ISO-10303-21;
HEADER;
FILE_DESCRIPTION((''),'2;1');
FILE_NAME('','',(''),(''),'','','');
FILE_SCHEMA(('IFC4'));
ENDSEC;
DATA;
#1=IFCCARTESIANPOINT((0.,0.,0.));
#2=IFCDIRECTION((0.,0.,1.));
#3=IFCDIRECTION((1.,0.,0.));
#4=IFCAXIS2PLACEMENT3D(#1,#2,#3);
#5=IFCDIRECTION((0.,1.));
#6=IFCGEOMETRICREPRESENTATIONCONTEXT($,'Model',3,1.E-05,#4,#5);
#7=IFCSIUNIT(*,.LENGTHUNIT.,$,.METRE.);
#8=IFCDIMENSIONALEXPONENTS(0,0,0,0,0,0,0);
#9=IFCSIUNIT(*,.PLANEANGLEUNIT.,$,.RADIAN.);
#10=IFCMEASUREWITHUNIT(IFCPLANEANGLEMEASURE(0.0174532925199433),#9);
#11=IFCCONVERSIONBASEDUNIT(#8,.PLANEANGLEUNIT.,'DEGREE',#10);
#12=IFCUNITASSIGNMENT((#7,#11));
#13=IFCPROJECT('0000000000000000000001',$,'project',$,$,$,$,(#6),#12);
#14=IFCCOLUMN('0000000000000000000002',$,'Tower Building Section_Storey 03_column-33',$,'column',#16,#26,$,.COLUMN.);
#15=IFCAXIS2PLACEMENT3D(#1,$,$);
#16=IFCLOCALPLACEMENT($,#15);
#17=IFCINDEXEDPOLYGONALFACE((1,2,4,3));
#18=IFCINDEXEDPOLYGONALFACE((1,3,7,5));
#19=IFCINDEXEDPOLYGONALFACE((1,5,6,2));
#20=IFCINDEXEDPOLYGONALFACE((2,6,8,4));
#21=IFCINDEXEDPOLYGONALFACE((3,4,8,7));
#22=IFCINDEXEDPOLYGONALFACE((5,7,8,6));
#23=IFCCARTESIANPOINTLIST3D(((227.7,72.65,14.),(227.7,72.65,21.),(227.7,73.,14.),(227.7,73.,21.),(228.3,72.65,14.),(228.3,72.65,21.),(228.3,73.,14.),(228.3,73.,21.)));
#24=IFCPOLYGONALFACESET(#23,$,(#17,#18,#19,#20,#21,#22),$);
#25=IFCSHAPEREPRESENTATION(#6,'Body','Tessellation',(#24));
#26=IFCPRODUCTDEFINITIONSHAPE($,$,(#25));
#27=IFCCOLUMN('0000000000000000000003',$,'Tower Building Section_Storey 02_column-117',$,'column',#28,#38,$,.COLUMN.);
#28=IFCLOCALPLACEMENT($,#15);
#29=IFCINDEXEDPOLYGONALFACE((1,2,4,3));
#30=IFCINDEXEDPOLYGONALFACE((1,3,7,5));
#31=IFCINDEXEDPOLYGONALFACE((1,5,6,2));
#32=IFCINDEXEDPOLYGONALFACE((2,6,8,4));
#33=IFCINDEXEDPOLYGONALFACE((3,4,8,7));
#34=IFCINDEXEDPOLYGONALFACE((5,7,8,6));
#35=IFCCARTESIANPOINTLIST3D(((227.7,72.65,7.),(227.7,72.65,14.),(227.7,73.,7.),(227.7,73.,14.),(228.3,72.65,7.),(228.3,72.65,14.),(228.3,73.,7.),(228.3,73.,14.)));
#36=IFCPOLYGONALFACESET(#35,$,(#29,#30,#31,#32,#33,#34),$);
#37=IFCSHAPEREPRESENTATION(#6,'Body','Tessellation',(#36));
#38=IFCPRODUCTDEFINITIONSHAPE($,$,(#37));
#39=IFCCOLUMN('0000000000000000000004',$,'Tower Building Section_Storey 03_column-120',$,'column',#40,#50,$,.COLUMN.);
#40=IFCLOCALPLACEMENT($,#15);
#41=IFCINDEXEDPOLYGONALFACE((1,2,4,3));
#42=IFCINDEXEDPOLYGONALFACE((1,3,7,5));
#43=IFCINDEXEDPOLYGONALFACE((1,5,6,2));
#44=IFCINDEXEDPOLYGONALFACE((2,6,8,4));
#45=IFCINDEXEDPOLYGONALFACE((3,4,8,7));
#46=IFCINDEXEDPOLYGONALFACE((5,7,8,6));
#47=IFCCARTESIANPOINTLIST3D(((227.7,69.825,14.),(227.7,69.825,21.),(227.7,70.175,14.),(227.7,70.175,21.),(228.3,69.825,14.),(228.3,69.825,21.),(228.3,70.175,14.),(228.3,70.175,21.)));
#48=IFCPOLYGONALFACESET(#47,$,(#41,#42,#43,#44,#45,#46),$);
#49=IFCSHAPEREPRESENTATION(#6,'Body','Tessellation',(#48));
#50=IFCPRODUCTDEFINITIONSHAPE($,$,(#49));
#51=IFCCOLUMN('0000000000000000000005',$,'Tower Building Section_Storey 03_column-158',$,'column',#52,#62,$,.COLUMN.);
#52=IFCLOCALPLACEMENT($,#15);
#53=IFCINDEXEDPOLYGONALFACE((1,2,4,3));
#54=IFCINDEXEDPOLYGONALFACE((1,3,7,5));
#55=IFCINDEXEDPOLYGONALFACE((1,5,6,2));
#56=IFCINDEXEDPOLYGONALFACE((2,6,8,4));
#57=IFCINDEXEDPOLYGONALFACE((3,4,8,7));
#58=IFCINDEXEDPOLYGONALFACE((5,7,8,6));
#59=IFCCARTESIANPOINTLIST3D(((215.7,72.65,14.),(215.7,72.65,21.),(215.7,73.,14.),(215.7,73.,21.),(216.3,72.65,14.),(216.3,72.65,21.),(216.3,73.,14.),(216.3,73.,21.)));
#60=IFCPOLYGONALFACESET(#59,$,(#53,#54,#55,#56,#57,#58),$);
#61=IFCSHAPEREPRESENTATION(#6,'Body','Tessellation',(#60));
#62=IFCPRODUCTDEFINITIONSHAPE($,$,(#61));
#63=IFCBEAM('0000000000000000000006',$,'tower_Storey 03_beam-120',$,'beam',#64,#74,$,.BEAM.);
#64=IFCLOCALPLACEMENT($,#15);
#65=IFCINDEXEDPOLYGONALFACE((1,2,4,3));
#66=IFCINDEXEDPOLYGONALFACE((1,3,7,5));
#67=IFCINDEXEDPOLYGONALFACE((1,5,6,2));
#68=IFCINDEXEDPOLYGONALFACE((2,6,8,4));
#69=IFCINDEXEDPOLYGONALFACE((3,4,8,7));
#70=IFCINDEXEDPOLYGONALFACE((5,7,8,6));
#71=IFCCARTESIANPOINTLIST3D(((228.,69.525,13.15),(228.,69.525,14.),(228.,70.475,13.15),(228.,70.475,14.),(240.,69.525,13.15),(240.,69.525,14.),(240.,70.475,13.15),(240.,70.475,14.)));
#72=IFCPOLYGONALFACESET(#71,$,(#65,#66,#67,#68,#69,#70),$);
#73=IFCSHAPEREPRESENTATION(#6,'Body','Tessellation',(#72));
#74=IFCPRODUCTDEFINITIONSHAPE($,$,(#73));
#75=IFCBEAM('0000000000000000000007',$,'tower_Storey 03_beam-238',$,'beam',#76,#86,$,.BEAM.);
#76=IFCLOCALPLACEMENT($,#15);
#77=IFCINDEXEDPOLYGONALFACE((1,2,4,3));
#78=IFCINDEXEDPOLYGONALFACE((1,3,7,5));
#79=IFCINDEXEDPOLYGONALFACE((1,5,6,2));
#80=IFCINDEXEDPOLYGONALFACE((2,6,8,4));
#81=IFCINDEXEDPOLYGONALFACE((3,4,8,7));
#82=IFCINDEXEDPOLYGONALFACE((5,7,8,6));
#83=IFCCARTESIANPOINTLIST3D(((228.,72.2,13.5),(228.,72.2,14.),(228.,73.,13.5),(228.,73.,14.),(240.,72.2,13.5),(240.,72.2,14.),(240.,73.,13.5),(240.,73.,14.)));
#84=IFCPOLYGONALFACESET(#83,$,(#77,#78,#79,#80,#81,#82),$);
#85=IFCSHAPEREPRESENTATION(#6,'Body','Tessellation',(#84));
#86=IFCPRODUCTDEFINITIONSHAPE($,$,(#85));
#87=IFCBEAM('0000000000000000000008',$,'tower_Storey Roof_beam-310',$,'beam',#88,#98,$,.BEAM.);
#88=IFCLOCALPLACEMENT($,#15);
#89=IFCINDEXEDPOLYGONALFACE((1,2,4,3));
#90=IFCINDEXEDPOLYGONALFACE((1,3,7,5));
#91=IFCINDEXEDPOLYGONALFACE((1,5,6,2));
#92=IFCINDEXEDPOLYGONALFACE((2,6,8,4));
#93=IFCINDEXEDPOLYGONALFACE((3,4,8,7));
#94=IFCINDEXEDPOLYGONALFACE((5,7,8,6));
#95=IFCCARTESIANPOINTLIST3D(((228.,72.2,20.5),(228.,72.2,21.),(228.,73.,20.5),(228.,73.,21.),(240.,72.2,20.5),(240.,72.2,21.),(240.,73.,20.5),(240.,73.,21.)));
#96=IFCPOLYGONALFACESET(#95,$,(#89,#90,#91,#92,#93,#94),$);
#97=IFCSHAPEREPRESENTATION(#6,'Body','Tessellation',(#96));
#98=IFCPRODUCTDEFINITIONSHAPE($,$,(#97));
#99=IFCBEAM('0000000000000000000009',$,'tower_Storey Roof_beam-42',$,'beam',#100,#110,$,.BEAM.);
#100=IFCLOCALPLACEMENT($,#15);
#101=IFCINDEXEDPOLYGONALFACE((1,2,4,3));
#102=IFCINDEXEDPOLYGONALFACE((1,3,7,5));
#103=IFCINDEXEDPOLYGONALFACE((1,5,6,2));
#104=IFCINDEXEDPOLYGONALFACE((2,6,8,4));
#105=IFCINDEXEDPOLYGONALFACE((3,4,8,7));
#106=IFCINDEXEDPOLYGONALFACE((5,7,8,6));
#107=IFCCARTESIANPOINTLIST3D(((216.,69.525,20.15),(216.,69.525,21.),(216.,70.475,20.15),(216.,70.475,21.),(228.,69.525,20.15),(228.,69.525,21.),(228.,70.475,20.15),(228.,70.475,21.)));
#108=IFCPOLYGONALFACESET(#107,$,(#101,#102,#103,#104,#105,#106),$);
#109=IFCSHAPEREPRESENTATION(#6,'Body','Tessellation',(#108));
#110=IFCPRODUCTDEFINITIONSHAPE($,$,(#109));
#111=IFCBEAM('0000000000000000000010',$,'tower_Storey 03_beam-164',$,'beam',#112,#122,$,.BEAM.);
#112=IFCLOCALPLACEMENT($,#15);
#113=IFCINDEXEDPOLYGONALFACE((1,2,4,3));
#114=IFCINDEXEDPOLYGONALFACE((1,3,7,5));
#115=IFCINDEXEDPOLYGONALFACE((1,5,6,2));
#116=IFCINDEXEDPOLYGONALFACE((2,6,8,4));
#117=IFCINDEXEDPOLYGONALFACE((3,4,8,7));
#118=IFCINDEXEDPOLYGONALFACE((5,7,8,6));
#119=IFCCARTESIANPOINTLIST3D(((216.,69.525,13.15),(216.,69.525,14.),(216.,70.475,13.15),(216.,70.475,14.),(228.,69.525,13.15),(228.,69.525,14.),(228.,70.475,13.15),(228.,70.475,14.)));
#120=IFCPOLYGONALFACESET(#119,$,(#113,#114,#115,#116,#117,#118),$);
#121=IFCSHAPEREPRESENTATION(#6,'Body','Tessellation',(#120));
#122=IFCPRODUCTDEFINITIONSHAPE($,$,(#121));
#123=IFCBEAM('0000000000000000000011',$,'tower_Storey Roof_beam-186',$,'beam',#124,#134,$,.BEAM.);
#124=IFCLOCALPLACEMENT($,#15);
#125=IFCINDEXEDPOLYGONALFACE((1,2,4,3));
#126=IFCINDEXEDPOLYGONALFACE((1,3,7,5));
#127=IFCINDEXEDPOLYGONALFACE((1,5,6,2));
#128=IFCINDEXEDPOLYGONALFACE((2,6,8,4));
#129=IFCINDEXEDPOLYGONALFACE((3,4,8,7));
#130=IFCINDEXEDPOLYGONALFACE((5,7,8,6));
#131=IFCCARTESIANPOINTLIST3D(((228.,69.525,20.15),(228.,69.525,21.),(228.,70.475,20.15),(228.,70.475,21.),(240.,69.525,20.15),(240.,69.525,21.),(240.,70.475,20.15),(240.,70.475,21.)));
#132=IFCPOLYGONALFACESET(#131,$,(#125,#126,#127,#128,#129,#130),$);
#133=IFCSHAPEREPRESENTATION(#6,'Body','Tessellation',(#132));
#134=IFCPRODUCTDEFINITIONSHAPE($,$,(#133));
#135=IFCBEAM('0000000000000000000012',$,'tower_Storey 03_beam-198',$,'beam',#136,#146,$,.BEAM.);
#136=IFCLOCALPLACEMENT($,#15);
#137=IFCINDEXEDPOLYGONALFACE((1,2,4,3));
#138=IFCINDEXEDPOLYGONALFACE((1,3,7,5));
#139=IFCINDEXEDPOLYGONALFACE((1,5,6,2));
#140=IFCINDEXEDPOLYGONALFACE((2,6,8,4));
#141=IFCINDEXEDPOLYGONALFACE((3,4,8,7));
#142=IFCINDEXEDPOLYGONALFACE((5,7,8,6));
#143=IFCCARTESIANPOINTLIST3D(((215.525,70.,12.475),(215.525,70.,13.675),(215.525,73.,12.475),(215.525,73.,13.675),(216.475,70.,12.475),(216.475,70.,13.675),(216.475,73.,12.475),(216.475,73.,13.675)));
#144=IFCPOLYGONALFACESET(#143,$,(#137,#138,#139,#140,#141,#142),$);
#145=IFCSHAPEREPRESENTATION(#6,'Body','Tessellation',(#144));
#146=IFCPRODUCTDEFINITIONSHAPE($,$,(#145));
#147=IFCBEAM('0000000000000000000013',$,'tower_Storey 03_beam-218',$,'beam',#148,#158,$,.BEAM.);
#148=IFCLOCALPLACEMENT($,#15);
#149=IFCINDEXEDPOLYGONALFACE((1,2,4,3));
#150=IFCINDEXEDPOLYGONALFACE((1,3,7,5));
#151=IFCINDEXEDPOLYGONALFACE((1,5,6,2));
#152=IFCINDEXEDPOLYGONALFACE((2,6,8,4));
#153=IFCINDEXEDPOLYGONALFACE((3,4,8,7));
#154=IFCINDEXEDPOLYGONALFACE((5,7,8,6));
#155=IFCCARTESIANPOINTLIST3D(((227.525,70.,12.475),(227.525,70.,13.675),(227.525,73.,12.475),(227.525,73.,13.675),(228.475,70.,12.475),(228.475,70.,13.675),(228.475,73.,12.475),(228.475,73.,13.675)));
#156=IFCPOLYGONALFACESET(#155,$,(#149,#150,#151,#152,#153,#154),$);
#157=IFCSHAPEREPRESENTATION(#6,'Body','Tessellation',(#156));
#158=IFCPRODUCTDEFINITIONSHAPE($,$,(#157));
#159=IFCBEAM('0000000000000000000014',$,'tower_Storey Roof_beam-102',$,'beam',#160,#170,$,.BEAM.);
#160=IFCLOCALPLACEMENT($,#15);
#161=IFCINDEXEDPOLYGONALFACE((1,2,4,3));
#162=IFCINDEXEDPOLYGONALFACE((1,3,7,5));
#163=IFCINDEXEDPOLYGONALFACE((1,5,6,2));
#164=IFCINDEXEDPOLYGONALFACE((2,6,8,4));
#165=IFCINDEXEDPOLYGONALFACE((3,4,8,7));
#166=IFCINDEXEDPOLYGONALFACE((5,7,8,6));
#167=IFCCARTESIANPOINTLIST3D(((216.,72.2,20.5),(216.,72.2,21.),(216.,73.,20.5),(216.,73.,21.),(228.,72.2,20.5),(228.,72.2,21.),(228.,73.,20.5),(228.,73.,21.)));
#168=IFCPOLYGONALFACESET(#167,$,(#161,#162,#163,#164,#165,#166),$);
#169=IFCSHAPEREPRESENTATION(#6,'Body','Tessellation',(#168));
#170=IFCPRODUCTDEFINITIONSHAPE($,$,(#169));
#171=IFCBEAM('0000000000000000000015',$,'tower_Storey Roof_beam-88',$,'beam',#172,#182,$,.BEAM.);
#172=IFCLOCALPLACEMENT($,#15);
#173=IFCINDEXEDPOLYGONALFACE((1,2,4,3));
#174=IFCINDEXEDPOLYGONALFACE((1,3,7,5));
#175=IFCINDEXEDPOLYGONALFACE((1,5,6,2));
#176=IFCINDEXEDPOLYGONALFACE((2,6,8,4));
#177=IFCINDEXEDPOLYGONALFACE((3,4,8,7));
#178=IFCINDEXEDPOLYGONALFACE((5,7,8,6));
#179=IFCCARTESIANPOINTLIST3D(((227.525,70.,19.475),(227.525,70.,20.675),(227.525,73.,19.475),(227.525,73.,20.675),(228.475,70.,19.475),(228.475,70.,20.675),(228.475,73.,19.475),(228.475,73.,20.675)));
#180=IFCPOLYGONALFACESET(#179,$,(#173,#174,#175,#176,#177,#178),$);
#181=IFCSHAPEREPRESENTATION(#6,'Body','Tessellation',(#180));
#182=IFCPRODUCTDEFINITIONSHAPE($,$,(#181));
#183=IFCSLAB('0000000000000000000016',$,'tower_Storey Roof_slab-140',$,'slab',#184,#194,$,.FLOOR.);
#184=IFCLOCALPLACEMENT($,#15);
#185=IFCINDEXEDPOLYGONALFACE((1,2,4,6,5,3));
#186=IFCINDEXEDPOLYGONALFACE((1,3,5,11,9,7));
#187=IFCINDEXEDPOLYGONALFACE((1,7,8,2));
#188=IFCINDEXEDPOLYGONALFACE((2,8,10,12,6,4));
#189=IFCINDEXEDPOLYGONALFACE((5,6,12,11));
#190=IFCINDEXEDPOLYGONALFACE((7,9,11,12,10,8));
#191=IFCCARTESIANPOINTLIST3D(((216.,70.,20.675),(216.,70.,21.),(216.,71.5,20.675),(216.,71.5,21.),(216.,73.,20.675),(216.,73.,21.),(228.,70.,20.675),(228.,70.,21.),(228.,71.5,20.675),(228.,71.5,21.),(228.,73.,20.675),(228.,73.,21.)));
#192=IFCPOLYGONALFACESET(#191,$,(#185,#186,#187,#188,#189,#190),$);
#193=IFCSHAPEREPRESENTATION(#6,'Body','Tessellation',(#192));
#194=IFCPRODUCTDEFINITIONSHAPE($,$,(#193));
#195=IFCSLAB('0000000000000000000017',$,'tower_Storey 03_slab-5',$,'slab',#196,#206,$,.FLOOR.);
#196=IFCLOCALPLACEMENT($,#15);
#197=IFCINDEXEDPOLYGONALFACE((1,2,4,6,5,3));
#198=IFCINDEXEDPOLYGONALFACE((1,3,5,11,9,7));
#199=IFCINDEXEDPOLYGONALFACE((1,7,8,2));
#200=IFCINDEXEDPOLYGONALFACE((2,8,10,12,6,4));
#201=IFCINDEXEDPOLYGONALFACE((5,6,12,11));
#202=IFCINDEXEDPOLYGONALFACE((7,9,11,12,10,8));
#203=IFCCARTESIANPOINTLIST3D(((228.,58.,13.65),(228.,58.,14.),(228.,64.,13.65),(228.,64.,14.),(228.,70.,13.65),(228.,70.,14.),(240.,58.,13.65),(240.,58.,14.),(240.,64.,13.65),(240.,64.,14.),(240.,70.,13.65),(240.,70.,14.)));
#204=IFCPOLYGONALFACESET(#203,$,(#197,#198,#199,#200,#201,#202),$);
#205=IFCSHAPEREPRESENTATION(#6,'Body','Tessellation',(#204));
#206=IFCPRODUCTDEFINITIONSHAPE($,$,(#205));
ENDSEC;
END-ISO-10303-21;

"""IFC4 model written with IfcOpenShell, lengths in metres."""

from ifc_helpers import new_model, entity, si_unit, converted_unit, direction, frame, origin_with_axes, place, context, project, polyline, outline, extrude, element, save


model = new_model("IFC4")

# Units and contexts
model_context = context("Model", 3, precision=1e-05, world=origin_with_axes(), true_north=direction((0.0, 1.0)))
ifc_project = project(units=[si_unit("LENGTHUNIT", "METRE"), converted_unit("PLANEANGLEUNIT", "DEGREE", entity("IfcPlaneAngleMeasure", 0.0174532925199433), si_unit("PLANEANGLEUNIT", "RADIAN"), dimensions=[0, 0, 0, 0, 0, 0, 0])], contexts=[model_context])

# Columns
placement_1 = place(None, origin_with_axes())
placement_2 = place(placement_1, frame((0.0, 0.0, 14.0), z_axis=(0.0, 0.0, 1.0), x_axis=(1.0, 0.0, 0.0)))
column_1_placement = place(placement_2, frame((228.0, 72.825, 0.0), z_axis=(0.0, 0.0, 1.0), x_axis=(1.0, 0.0, 0.0)))
element("IfcColumn", 1, at=column_1_placement, Name="Tower Building Section_Storey 03_column-33", ObjectType="column", PredefinedType="COLUMN", context=model_context, body=[
    extrude(outline(polyline([(-0.3, -0.175, 0.0), (0.3, -0.175, 0.0), (0.3, 0.175, 0.0), (-0.3, 0.175, 0.0), (-0.3, -0.175, 0.0)])), origin_with_axes(), (0.0, 0.0, 1.0), 7.0),
])
placement_3 = place(placement_1, frame((0.0, 0.0, 7.0), z_axis=(0.0, 0.0, 1.0), x_axis=(1.0, 0.0, 0.0)))
column_2_placement = place(placement_3, frame((228.0, 72.825, 0.0), z_axis=(0.0, 0.0, 1.0), x_axis=(1.0, 0.0, 0.0)))
element("IfcColumn", 2, at=column_2_placement, Name="Tower Building Section_Storey 02_column-117", ObjectType="column", PredefinedType="COLUMN", context=model_context, body=[
    extrude(outline(polyline([(-0.3, -0.175, 0.0), (0.3, -0.175, 0.0), (0.3, 0.175, 0.0), (-0.3, 0.175, 0.0), (-0.3, -0.175, 0.0)])), origin_with_axes(), (0.0, 0.0, 1.0), 7.0),
])
for number, where, z_axis, x_axis, name in (
    (3, (228.0, 70.0, 0.0), (0.0, 0.0, 1.0), (1.0, 0.0, 0.0), "Tower Building Section_Storey 03_column-120"),
    (4, (216.0, 72.825, 0.0), (0.0, 0.0, 1.0), (1.0, 0.0, 0.0), "Tower Building Section_Storey 03_column-158"),
):
    element("IfcColumn", number, at=place(placement_2, frame(where, z_axis=z_axis, x_axis=x_axis)), Name=name, ObjectType="column", PredefinedType="COLUMN", context=model_context, body=[
        extrude(outline(polyline([(-0.3, -0.175, 0.0), (0.3, -0.175, 0.0), (0.3, 0.175, 0.0), (-0.3, 0.175, 0.0), (-0.3, -0.175, 0.0)])), origin_with_axes(), (0.0, 0.0, 1.0), 7.0),
    ])

# Beams
beam_1_placement = place(placement_2, frame((228.0, 70.0, -0.425), z_axis=(1.0, 0.0, 0.0), x_axis=(0.0, 1.0, 0.0)))
element("IfcBeam", 5, at=beam_1_placement, Name="tower_Storey 03_beam-120", ObjectType="beam", PredefinedType="BEAM", context=model_context, body=[
    extrude(outline(polyline([(0.475, 0.425, 0.0), (-0.475, 0.425, 0.0), (-0.475, -0.425, 0.0), (0.475, -0.425, 0.0), (0.475, 0.425, 0.0)])), origin_with_axes(), (0.0, 0.0, 1.0), 12.0),
])
beam_2_placement = place(placement_2, frame((228.0, 72.6, -0.25), z_axis=(1.0, 0.0, 0.0), x_axis=(0.0, 1.0, 0.0)))
element("IfcBeam", 6, at=beam_2_placement, Name="tower_Storey 03_beam-238", ObjectType="beam", PredefinedType="BEAM", context=model_context, body=[
    extrude(outline(polyline([(0.4, 0.25, 0.0), (-0.4, 0.25, 0.0), (-0.4, -0.25, 0.0), (0.4, -0.25, 0.0), (0.4, 0.25, 0.0)])), origin_with_axes(), (0.0, 0.0, 1.0), 12.0),
])
placement_4 = place(placement_1, frame((0.0, 0.0, 21.0), z_axis=(0.0, 0.0, 1.0), x_axis=(1.0, 0.0, 0.0)))
beam_3_placement = place(placement_4, frame((228.0, 72.6, -0.25), z_axis=(1.0, 0.0, 0.0), x_axis=(0.0, 1.0, 0.0)))
element("IfcBeam", 7, at=beam_3_placement, Name="tower_Storey Roof_beam-310", ObjectType="beam", PredefinedType="BEAM", context=model_context, body=[
    extrude(outline(polyline([(0.4, 0.25, 0.0), (-0.4, 0.25, 0.0), (-0.4, -0.25, 0.0), (0.4, -0.25, 0.0), (0.4, 0.25, 0.0)])), origin_with_axes(), (0.0, 0.0, 1.0), 12.0),
])
beam_4_placement = place(placement_4, frame((216.0, 70.0, -0.425), z_axis=(1.0, 0.0, 0.0), x_axis=(0.0, 1.0, 0.0)))
element("IfcBeam", 8, at=beam_4_placement, Name="tower_Storey Roof_beam-42", ObjectType="beam", PredefinedType="BEAM", context=model_context, body=[
    extrude(outline(polyline([(0.475, 0.425, 0.0), (-0.475, 0.425, 0.0), (-0.475, -0.425, 0.0), (0.475, -0.425, 0.0), (0.475, 0.425, 0.0)])), origin_with_axes(), (0.0, 0.0, 1.0), 12.0),
])
beam_5_placement = place(placement_2, frame((216.0, 70.0, -0.425), z_axis=(1.0, 0.0, 0.0), x_axis=(0.0, 1.0, 0.0)))
element("IfcBeam", 9, at=beam_5_placement, Name="tower_Storey 03_beam-164", ObjectType="beam", PredefinedType="BEAM", context=model_context, body=[
    extrude(outline(polyline([(0.475, 0.425, 0.0), (-0.475, 0.425, 0.0), (-0.475, -0.425, 0.0), (0.475, -0.425, 0.0), (0.475, 0.425, 0.0)])), origin_with_axes(), (0.0, 0.0, 1.0), 12.0),
])
beam_6_placement = place(placement_4, frame((228.0, 70.0, -0.425), z_axis=(1.0, 0.0, 0.0), x_axis=(0.0, 1.0, 0.0)))
element("IfcBeam", 10, at=beam_6_placement, Name="tower_Storey Roof_beam-186", ObjectType="beam", PredefinedType="BEAM", context=model_context, body=[
    extrude(outline(polyline([(0.475, 0.425, 0.0), (-0.475, 0.425, 0.0), (-0.475, -0.425, 0.0), (0.475, -0.425, 0.0), (0.475, 0.425, 0.0)])), origin_with_axes(), (0.0, 0.0, 1.0), 12.0),
])
for number, where, z_axis, x_axis, name in (
    (11, (216.0, 70.0, -0.925), (0.0, 1.0, 0.0), (-1.0, 0.0, 0.0), "tower_Storey 03_beam-198"),
    (12, (228.0, 70.0, -0.925), (0.0, 1.0, 0.0), (-1.0, 0.0, 0.0), "tower_Storey 03_beam-218"),
):
    element("IfcBeam", number, at=place(placement_2, frame(where, z_axis=z_axis, x_axis=x_axis)), Name=name, ObjectType="beam", PredefinedType="BEAM", context=model_context, body=[
        extrude(outline(polyline([(0.475, 0.6, 0.0), (-0.475, 0.6, 0.0), (-0.475, -0.6, 0.0), (0.475, -0.6, 0.0), (0.475, 0.6, 0.0)])), origin_with_axes(), (0.0, 0.0, 1.0), 3.0),
    ])
beam_7_placement = place(placement_4, frame((216.0, 72.6, -0.25), z_axis=(1.0, 0.0, 0.0), x_axis=(0.0, 1.0, 0.0)))
element("IfcBeam", 13, at=beam_7_placement, Name="tower_Storey Roof_beam-102", ObjectType="beam", PredefinedType="BEAM", context=model_context, body=[
    extrude(outline(polyline([(0.4, 0.25, 0.0), (-0.4, 0.25, 0.0), (-0.4, -0.25, 0.0), (0.4, -0.25, 0.0), (0.4, 0.25, 0.0)])), origin_with_axes(), (0.0, 0.0, 1.0), 12.0),
])
beam_8_placement = place(placement_4, frame((228.0, 70.0, -0.925), z_axis=(0.0, 1.0, 0.0), x_axis=(-1.0, 0.0, 0.0)))
element("IfcBeam", 14, at=beam_8_placement, Name="tower_Storey Roof_beam-88", ObjectType="beam", PredefinedType="BEAM", context=model_context, body=[
    extrude(outline(polyline([(0.475, 0.6, 0.0), (-0.475, 0.6, 0.0), (-0.475, -0.6, 0.0), (0.475, -0.6, 0.0), (0.475, 0.6, 0.0)])), origin_with_axes(), (0.0, 0.0, 1.0), 3.0),
])

# Slabs
slab_1_placement = place(placement_4, frame((222.0, 71.5, -0.325), z_axis=(0.0, 0.0, 1.0), x_axis=(1.0, 0.0, 0.0)))
element("IfcSlab", 15, at=slab_1_placement, Name="tower_Storey Roof_slab-140", ObjectType="slab", PredefinedType="FLOOR", context=model_context, body=[
    extrude(outline(polyline([(-6.0, 0.0, 0.0), (-6.0, -1.5, 0.0), (6.0, -1.5, 0.0), (6.0, 0.0, 0.0), (6.0, 1.5, 0.0), (-6.0, 1.5, 0.0), (-6.0, 0.0, 0.0)])), origin_with_axes(), (0.0, 0.0, 1.0), 0.325),
])
slab_2_placement = place(placement_2, frame((234.0, 64.0, -0.35), z_axis=(0.0, 0.0, 1.0), x_axis=(1.0, 0.0, 0.0)))
element("IfcSlab", 16, at=slab_2_placement, Name="tower_Storey 03_slab-5", ObjectType="slab", PredefinedType="FLOOR", context=model_context, body=[
    extrude(outline(polyline([(-6.0, -6.0, 0.0), (6.0, -6.0, 0.0), (6.0, 0.0, 0.0), (6.0, 6.0, 0.0), (-6.0, 6.0, 0.0), (-6.0, 0.0, 0.0), (-6.0, -6.0, 0.0)])), origin_with_axes(), (0.0, 0.0, 1.0), 0.35),
])

save(model, "model.ifc")
